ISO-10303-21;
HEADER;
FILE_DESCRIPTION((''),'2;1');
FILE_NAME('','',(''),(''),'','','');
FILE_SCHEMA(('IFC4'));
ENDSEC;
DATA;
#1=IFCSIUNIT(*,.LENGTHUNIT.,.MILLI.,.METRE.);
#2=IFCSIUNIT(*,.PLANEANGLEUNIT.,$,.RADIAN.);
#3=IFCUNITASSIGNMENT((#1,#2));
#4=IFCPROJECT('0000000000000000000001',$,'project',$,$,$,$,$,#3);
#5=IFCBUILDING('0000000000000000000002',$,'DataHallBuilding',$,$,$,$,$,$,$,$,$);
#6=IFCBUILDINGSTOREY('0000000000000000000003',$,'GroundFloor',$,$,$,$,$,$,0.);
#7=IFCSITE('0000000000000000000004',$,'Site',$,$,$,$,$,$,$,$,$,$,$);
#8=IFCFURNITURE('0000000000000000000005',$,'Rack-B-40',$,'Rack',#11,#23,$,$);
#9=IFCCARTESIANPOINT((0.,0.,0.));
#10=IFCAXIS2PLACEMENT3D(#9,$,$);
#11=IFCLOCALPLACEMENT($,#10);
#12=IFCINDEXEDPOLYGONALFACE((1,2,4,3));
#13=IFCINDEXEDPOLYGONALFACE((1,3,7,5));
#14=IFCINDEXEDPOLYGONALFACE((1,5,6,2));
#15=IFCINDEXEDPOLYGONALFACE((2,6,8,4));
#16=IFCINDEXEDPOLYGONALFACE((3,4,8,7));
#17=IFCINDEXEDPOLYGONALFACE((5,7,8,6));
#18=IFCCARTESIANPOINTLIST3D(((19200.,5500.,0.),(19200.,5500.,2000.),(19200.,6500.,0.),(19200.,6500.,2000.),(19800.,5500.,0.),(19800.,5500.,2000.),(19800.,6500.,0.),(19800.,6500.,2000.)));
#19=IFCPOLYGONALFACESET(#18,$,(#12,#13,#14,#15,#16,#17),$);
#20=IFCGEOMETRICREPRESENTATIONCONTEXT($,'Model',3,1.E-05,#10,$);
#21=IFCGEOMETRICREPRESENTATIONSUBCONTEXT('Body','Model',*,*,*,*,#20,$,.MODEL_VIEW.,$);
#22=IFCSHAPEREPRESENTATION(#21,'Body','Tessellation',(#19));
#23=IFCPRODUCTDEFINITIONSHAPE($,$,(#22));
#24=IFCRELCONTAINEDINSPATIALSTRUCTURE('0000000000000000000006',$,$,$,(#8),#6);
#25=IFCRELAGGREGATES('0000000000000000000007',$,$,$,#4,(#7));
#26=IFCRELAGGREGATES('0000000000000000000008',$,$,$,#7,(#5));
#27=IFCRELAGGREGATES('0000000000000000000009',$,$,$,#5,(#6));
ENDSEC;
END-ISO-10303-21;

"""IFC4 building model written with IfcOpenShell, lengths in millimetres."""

from ifc_helpers import new_model, si_unit, frame, origin, place, context, subcontext, project, spatial, rectangle, extrude, element, save


model = new_model("IFC4")

# Units and contexts
model_context = context("Model", 3, precision=1e-05, world=origin())
body_context = subcontext(model_context, "Body", "Model", "MODEL_VIEW")
ifc_project = project(units=[si_unit("LENGTHUNIT", "METRE", prefix="MILLI"), si_unit("PLANEANGLEUNIT", "RADIAN")])

# Site, building, storey
site = spatial("IfcSite", under=ifc_project, Name="Site")
building = spatial("IfcBuilding", under=site, Name="DataHallBuilding")
storey = spatial("IfcBuildingStorey", under=building, Name="GroundFloor", Elevation=0.0)

# Furniture
furniture_1_placement = place(None, origin())
element("IfcFurniture", 1, at=furniture_1_placement, inside=storey, Name="Rack-B-40", ObjectType="Rack", context=body_context, shape_type="SweptSolid", body=[
    extrude(rectangle(XDim=600.0, YDim=1000.0), frame((19500.0, 6000.0, 0.0), z_axis=(0.0, 0.0, 1.0), x_axis=(1.0, 0.0, 0.0)), (0.0, 0.0, 1.0), 2000.0),
])

save(model, "model.ifc")
